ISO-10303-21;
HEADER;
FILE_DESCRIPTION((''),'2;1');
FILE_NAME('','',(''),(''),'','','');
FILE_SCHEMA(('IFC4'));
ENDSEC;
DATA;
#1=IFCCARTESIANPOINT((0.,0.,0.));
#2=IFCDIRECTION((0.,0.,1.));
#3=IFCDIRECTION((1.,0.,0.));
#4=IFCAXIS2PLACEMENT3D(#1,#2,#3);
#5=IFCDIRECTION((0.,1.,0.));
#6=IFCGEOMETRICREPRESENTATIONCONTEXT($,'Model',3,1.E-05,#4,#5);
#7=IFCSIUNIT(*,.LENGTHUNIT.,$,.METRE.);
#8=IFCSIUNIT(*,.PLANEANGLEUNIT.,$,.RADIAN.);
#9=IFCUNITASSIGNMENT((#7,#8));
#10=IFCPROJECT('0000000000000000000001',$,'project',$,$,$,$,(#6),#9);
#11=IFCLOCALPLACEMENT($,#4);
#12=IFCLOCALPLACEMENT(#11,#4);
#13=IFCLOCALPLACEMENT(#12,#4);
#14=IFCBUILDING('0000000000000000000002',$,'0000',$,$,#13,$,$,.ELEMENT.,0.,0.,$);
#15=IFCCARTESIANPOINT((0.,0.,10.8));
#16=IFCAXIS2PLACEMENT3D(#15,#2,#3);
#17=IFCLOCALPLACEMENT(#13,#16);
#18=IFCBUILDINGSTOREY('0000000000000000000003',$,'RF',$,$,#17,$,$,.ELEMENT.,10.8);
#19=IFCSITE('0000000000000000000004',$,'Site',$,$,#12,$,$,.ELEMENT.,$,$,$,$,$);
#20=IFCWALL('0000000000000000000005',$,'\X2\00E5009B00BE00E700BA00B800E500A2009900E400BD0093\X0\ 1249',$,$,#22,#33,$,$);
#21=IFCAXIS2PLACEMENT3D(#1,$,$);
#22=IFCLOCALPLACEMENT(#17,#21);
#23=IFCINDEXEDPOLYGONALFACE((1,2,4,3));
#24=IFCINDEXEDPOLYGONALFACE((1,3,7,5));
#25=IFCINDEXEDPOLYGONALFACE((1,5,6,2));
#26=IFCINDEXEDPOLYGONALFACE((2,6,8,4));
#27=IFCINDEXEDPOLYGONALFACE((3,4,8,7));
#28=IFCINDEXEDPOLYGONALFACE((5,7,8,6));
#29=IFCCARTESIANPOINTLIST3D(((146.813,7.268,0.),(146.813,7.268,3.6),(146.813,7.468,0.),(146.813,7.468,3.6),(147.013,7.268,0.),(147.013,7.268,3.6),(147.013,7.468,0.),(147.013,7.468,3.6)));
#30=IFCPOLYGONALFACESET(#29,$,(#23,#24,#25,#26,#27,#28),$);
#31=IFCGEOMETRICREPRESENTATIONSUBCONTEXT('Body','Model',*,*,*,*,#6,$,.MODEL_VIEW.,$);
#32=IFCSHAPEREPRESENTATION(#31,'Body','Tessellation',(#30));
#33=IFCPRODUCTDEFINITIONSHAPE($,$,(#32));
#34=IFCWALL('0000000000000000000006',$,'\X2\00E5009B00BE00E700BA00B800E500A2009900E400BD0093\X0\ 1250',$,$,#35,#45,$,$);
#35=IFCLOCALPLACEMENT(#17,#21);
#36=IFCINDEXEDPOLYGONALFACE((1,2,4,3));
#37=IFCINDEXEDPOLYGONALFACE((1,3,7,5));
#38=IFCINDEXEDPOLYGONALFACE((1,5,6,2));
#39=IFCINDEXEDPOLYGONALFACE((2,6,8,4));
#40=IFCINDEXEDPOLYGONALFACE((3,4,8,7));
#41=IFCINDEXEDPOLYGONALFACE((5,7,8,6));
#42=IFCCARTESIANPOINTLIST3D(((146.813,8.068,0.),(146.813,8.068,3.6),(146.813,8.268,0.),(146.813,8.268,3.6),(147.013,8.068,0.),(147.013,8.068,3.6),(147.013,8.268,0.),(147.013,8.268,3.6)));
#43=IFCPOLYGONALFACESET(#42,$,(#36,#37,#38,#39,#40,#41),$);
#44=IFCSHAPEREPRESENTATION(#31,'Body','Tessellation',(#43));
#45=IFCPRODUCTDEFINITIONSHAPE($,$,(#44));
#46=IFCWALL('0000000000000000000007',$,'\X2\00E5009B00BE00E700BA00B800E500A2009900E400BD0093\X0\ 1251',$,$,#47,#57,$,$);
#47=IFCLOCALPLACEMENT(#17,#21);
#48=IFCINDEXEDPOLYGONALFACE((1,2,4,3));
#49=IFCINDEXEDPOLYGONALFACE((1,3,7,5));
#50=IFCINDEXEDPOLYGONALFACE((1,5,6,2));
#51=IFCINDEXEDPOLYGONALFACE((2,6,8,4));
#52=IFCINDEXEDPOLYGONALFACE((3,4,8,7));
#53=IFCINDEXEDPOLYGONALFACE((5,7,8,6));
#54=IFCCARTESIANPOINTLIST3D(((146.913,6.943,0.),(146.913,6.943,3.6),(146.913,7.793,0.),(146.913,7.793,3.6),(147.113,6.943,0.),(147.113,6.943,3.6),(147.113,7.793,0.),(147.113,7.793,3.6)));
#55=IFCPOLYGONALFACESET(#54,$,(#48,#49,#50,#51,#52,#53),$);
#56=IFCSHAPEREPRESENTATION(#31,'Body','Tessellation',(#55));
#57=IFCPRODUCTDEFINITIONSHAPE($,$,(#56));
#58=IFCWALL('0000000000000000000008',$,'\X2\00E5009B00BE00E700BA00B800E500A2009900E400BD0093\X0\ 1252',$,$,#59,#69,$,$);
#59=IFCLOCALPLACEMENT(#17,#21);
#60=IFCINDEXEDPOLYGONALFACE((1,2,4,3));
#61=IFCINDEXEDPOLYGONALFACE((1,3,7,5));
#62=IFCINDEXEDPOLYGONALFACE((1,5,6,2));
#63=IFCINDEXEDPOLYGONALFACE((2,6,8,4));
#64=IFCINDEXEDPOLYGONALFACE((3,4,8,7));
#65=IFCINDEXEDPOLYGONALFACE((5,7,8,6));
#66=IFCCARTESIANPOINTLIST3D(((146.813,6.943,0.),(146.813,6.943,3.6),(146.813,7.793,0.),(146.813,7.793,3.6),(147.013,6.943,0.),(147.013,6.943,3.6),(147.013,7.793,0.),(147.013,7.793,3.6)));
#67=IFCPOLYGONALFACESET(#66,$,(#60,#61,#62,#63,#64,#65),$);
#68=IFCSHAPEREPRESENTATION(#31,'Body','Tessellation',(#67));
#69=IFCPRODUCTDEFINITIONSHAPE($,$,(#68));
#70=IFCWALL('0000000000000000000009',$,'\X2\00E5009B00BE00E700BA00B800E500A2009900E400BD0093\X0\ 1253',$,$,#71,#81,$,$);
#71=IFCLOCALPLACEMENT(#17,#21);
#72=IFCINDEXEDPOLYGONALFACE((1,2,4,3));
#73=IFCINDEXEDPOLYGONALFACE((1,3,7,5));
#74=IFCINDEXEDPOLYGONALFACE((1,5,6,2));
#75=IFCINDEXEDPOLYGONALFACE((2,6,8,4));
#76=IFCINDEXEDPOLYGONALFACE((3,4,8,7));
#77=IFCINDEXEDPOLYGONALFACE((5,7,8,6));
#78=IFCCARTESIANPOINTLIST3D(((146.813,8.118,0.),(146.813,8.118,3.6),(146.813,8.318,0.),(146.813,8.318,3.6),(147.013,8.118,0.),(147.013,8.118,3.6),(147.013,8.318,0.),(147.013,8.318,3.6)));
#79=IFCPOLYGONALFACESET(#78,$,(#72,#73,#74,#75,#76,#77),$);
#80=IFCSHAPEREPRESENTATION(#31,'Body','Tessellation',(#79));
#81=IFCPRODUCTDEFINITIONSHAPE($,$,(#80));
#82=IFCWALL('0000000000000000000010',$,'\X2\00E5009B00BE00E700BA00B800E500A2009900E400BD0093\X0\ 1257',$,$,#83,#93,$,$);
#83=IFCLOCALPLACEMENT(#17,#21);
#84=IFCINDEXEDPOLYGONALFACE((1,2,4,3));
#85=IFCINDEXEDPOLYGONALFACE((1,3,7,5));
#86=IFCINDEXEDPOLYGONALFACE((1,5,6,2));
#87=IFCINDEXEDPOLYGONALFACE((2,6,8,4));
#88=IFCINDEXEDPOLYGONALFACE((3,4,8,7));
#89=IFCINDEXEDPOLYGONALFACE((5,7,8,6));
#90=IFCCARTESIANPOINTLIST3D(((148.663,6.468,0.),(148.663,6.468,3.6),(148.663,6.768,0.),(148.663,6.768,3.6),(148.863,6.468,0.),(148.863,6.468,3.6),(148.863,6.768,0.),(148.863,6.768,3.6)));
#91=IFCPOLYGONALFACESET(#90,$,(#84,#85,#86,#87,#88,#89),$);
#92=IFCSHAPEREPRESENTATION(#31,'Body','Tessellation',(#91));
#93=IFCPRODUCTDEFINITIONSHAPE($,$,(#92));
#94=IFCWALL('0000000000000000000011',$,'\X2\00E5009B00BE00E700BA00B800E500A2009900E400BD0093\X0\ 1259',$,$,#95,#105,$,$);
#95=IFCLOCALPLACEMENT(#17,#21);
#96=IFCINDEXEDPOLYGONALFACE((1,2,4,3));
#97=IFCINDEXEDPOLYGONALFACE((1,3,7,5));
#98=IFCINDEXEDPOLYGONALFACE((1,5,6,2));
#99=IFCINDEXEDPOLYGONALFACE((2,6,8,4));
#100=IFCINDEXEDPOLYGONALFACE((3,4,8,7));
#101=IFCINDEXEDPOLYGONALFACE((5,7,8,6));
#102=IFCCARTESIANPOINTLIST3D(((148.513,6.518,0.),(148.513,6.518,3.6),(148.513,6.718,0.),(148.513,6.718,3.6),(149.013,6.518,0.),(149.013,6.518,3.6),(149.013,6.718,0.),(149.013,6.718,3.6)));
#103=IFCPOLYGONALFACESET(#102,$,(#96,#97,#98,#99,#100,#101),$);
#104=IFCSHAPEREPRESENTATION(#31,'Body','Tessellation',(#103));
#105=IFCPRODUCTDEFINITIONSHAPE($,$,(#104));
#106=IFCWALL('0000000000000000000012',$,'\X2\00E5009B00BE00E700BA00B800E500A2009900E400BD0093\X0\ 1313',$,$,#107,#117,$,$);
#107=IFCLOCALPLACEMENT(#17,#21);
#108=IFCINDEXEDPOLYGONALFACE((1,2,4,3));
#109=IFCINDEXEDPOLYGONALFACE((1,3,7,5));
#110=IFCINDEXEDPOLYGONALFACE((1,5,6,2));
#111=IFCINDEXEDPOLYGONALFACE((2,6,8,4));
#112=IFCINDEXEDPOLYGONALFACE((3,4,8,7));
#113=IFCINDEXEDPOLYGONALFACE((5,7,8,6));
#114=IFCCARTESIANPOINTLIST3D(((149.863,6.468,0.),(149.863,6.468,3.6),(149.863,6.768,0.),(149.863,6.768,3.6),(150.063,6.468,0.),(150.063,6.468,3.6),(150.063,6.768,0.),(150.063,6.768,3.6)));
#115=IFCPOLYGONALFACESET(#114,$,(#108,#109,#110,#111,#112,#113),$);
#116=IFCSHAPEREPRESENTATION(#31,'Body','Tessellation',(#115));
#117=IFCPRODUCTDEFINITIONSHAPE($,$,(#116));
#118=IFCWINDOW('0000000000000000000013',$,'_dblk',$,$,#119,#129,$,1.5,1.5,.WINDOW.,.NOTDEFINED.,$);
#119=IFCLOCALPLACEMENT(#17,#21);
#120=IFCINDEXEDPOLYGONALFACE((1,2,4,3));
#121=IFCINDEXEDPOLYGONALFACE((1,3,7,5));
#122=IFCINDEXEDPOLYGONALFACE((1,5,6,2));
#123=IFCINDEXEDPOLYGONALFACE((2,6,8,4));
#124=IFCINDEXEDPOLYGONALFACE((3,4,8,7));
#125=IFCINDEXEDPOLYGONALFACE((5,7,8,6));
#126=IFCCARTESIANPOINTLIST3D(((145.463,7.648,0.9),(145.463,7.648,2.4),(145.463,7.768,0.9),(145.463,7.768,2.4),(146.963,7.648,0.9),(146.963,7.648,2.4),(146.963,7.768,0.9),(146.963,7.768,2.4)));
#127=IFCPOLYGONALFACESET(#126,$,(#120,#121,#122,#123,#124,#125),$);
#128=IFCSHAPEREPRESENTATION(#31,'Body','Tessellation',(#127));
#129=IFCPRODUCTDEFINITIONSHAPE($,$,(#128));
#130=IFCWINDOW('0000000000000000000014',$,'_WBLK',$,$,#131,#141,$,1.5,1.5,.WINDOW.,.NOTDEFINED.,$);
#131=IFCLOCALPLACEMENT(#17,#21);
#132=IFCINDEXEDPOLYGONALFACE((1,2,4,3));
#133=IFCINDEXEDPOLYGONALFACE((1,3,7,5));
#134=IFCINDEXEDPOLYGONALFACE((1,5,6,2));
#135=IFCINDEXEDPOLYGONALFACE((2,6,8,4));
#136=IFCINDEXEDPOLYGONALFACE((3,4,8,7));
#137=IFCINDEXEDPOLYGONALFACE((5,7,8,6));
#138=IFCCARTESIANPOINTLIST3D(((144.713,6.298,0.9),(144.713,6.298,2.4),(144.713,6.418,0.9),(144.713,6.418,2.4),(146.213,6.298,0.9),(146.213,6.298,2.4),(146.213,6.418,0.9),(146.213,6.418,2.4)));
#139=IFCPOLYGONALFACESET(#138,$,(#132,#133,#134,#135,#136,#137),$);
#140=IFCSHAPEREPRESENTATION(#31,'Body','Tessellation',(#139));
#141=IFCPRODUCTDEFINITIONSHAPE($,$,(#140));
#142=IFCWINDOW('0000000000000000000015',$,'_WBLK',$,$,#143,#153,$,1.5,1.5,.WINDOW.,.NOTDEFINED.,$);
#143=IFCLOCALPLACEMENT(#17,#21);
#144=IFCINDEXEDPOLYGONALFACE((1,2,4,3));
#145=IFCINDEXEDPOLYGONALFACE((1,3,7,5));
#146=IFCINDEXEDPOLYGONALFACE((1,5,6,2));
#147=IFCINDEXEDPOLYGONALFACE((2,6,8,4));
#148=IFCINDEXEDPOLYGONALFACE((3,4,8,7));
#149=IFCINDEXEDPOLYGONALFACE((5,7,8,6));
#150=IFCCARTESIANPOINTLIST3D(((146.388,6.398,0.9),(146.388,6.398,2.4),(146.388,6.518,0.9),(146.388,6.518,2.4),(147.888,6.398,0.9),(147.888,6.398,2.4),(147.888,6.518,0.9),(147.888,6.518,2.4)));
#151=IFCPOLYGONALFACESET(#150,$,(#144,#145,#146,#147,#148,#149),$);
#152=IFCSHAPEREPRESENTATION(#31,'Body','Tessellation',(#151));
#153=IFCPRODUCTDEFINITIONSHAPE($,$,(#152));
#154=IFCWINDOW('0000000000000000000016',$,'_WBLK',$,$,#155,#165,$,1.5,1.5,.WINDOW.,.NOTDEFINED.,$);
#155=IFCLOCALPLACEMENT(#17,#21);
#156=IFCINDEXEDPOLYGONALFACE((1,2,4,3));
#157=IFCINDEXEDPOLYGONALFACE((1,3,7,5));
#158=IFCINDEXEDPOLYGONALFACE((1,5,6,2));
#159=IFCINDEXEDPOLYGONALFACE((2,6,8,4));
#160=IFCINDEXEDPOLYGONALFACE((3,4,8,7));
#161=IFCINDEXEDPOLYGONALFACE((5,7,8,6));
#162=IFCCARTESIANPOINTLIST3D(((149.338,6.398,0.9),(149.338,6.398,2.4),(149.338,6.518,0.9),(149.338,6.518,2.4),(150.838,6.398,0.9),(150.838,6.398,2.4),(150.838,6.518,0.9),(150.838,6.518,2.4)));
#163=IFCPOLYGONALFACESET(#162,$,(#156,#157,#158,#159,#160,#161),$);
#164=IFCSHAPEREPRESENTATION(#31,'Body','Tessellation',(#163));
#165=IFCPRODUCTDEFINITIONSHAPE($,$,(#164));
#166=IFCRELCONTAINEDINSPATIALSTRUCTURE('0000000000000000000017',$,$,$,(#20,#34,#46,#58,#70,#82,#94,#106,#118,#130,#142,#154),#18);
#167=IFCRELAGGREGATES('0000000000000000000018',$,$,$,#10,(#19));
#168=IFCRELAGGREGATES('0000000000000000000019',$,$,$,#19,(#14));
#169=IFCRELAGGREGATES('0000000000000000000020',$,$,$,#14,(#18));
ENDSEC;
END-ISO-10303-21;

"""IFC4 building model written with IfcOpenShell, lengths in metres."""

from ifc_helpers import new_model, si_unit, direction, frame, frame_2d, origin_with_axes, place, context, subcontext, project, spatial, rectangle, extrude, element, save


model = new_model("IFC4")

# Units and contexts
model_context = context("Model", 3, precision=1e-05, world=origin_with_axes(), true_north=direction((0.0, 1.0, 0.0)))
body_context = subcontext(model_context, "Body", "Model", "MODEL_VIEW")
ifc_project = project(units=[si_unit("LENGTHUNIT", "METRE"), si_unit("PLANEANGLEUNIT", "RADIAN")], contexts=[model_context])

# Site, building, storey
placement = place(None, origin_with_axes())
site_placement = place(placement, origin_with_axes())
site = spatial("IfcSite", under=ifc_project, at=site_placement, Name="Site", CompositionType="ELEMENT")
building_placement = place(site_placement, origin_with_axes())
building = spatial("IfcBuilding", under=site, at=building_placement, Name="0000", CompositionType="ELEMENT", ElevationOfRefHeight=0.0, ElevationOfTerrain=0.0)
storey_placement = place(building_placement, frame((0.0, 0.0, 10.8), z_axis=(0.0, 0.0, 1.0), x_axis=(1.0, 0.0, 0.0)))
storey = spatial("IfcBuildingStorey", under=building, at=storey_placement, Name="RF", CompositionType="ELEMENT", Elevation=10.8)

# Walls
for number, where, z_axis, x_axis, name in (
    (1, (146.913, 7.368, 0.0), (0.0, 0.0, 1.0), (1.0, 0.0, 0.0), "å\u009b¾çº¸å¢\u0099ä½\u0093 1249"),
    (2, (146.913, 8.168, 0.0), (0.0, 0.0, 1.0), (1.0, 0.0, 0.0), "å\u009b¾çº¸å¢\u0099ä½\u0093 1250"),
):
    element("IfcWall", number, at=place(storey_placement, frame(where, z_axis=z_axis, x_axis=x_axis)), inside=storey, Name=name, context=body_context, shape_type="SweptSolid", body=[
        extrude(rectangle(XDim=0.2, YDim=0.2, at=frame_2d((0.0, 0.0), x_axis=(1.0, 0.0, 0.0))), frame((0.0, 0.0, 0.0), z_axis=(0.0, 0.0, 1.0)), (0.0, 0.0, 1.0), 3.6),
    ])
for number, where, z_axis, x_axis, name in (
    (3, (147.013, 7.368, 0.0), (0.0, 0.0, 1.0), (0.0, -1.0, 0.0), "å\u009b¾çº¸å¢\u0099ä½\u0093 1251"),
    (4, (146.913, 7.368, 0.0), (0.0, 0.0, 1.0), (0.0, -1.0, 0.0), "å\u009b¾çº¸å¢\u0099ä½\u0093 1252"),
):
    element("IfcWall", number, at=place(storey_placement, frame(where, z_axis=z_axis, x_axis=x_axis)), inside=storey, Name=name, context=body_context, shape_type="SweptSolid", body=[
        extrude(rectangle(XDim=0.85, YDim=0.2, at=frame_2d((0.0, 0.0), x_axis=(1.0, 0.0, 0.0))), frame((0.0, 0.0, 0.0), z_axis=(0.0, 0.0, 1.0)), (0.0, 0.0, 1.0), 3.6),
    ])
wall_1_placement = place(storey_placement, frame((146.913, 8.218, 0.0), z_axis=(0.0, 0.0, 1.0), x_axis=(0.0, -1.0, 0.0)))
element("IfcWall", 5, at=wall_1_placement, inside=storey, Name="å\u009b¾çº¸å¢\u0099ä½\u0093 1253", context=body_context, shape_type="SweptSolid", body=[
    extrude(rectangle(XDim=0.2, YDim=0.2, at=frame_2d((0.0, 0.0), x_axis=(1.0, 0.0, 0.0))), frame((0.0, 0.0, 0.0), z_axis=(0.0, 0.0, 1.0)), (0.0, 0.0, 1.0), 3.6),
])
wall_2_placement = place(storey_placement, frame((148.763, 6.618, 0.0), z_axis=(0.0, 0.0, 1.0), x_axis=(0.0, -1.0, 0.0)))
element("IfcWall", 6, at=wall_2_placement, inside=storey, Name="å\u009b¾çº¸å¢\u0099ä½\u0093 1257", context=body_context, shape_type="SweptSolid", body=[
    extrude(rectangle(XDim=0.3, YDim=0.2, at=frame_2d((0.0, 0.0), x_axis=(1.0, 0.0, 0.0))), frame((0.0, 0.0, 0.0), z_axis=(0.0, 0.0, 1.0)), (0.0, 0.0, 1.0), 3.6),
])
wall_3_placement = place(storey_placement, frame((148.763, 6.618, 0.0), z_axis=(0.0, 0.0, 1.0), x_axis=(1.0, 0.0, 0.0)))
element("IfcWall", 7, at=wall_3_placement, inside=storey, Name="å\u009b¾çº¸å¢\u0099ä½\u0093 1259", context=body_context, shape_type="SweptSolid", body=[
    extrude(rectangle(XDim=0.5, YDim=0.2, at=frame_2d((0.0, 0.0), x_axis=(1.0, 0.0, 0.0))), frame((0.0, 0.0, 0.0), z_axis=(0.0, 0.0, 1.0)), (0.0, 0.0, 1.0), 3.6),
])
wall_4_placement = place(storey_placement, frame((149.963, 6.618, 0.0), z_axis=(0.0, 0.0, 1.0), x_axis=(0.0, -1.0, 0.0)))
element("IfcWall", 8, at=wall_4_placement, inside=storey, Name="å\u009b¾çº¸å¢\u0099ä½\u0093 1313", context=body_context, shape_type="SweptSolid", body=[
    extrude(rectangle(XDim=0.3, YDim=0.2, at=frame_2d((0.0, 0.0), x_axis=(1.0, 0.0, 0.0))), frame((0.0, 0.0, 0.0), z_axis=(0.0, 0.0, 1.0)), (0.0, 0.0, 1.0), 3.6),
])

# Windows
for number, where, z_axis, x_axis, name in (
    (9, (146.213, 7.708, 0.9), (0.0, 0.0, 1.0), (1.0, 0.0, 0.0), "_dblk"),
    (10, (145.463, 6.358, 0.9), (0.0, 0.0, 1.0), (1.0, 0.0, 0.0), "_WBLK"),
    (11, (147.138, 6.458, 0.9), (0.0, 0.0, 1.0), (1.0, 0.0, 0.0), "_WBLK"),
    (12, (150.088, 6.458, 0.9), (0.0, 0.0, 1.0), (1.0, 0.0, 0.0), "_WBLK"),
):
    element("IfcWindow", number, at=place(storey_placement, frame(where, z_axis=z_axis, x_axis=x_axis)), inside=storey, Name=name, OverallHeight=1.5, OverallWidth=1.5, PartitioningType="NOTDEFINED", PredefinedType="WINDOW", context=body_context, shape_type="SweptSolid", body=[
        extrude(rectangle(XDim=1.5, YDim=0.12, at=frame_2d((0.0, 0.0), x_axis=(1.0, 0.0, 0.0))), frame((0.0, 0.0, 0.0), z_axis=(0.0, 0.0, 1.0)), (0.0, 0.0, 1.0), 1.5),
    ])

save(model, "model.ifc")
